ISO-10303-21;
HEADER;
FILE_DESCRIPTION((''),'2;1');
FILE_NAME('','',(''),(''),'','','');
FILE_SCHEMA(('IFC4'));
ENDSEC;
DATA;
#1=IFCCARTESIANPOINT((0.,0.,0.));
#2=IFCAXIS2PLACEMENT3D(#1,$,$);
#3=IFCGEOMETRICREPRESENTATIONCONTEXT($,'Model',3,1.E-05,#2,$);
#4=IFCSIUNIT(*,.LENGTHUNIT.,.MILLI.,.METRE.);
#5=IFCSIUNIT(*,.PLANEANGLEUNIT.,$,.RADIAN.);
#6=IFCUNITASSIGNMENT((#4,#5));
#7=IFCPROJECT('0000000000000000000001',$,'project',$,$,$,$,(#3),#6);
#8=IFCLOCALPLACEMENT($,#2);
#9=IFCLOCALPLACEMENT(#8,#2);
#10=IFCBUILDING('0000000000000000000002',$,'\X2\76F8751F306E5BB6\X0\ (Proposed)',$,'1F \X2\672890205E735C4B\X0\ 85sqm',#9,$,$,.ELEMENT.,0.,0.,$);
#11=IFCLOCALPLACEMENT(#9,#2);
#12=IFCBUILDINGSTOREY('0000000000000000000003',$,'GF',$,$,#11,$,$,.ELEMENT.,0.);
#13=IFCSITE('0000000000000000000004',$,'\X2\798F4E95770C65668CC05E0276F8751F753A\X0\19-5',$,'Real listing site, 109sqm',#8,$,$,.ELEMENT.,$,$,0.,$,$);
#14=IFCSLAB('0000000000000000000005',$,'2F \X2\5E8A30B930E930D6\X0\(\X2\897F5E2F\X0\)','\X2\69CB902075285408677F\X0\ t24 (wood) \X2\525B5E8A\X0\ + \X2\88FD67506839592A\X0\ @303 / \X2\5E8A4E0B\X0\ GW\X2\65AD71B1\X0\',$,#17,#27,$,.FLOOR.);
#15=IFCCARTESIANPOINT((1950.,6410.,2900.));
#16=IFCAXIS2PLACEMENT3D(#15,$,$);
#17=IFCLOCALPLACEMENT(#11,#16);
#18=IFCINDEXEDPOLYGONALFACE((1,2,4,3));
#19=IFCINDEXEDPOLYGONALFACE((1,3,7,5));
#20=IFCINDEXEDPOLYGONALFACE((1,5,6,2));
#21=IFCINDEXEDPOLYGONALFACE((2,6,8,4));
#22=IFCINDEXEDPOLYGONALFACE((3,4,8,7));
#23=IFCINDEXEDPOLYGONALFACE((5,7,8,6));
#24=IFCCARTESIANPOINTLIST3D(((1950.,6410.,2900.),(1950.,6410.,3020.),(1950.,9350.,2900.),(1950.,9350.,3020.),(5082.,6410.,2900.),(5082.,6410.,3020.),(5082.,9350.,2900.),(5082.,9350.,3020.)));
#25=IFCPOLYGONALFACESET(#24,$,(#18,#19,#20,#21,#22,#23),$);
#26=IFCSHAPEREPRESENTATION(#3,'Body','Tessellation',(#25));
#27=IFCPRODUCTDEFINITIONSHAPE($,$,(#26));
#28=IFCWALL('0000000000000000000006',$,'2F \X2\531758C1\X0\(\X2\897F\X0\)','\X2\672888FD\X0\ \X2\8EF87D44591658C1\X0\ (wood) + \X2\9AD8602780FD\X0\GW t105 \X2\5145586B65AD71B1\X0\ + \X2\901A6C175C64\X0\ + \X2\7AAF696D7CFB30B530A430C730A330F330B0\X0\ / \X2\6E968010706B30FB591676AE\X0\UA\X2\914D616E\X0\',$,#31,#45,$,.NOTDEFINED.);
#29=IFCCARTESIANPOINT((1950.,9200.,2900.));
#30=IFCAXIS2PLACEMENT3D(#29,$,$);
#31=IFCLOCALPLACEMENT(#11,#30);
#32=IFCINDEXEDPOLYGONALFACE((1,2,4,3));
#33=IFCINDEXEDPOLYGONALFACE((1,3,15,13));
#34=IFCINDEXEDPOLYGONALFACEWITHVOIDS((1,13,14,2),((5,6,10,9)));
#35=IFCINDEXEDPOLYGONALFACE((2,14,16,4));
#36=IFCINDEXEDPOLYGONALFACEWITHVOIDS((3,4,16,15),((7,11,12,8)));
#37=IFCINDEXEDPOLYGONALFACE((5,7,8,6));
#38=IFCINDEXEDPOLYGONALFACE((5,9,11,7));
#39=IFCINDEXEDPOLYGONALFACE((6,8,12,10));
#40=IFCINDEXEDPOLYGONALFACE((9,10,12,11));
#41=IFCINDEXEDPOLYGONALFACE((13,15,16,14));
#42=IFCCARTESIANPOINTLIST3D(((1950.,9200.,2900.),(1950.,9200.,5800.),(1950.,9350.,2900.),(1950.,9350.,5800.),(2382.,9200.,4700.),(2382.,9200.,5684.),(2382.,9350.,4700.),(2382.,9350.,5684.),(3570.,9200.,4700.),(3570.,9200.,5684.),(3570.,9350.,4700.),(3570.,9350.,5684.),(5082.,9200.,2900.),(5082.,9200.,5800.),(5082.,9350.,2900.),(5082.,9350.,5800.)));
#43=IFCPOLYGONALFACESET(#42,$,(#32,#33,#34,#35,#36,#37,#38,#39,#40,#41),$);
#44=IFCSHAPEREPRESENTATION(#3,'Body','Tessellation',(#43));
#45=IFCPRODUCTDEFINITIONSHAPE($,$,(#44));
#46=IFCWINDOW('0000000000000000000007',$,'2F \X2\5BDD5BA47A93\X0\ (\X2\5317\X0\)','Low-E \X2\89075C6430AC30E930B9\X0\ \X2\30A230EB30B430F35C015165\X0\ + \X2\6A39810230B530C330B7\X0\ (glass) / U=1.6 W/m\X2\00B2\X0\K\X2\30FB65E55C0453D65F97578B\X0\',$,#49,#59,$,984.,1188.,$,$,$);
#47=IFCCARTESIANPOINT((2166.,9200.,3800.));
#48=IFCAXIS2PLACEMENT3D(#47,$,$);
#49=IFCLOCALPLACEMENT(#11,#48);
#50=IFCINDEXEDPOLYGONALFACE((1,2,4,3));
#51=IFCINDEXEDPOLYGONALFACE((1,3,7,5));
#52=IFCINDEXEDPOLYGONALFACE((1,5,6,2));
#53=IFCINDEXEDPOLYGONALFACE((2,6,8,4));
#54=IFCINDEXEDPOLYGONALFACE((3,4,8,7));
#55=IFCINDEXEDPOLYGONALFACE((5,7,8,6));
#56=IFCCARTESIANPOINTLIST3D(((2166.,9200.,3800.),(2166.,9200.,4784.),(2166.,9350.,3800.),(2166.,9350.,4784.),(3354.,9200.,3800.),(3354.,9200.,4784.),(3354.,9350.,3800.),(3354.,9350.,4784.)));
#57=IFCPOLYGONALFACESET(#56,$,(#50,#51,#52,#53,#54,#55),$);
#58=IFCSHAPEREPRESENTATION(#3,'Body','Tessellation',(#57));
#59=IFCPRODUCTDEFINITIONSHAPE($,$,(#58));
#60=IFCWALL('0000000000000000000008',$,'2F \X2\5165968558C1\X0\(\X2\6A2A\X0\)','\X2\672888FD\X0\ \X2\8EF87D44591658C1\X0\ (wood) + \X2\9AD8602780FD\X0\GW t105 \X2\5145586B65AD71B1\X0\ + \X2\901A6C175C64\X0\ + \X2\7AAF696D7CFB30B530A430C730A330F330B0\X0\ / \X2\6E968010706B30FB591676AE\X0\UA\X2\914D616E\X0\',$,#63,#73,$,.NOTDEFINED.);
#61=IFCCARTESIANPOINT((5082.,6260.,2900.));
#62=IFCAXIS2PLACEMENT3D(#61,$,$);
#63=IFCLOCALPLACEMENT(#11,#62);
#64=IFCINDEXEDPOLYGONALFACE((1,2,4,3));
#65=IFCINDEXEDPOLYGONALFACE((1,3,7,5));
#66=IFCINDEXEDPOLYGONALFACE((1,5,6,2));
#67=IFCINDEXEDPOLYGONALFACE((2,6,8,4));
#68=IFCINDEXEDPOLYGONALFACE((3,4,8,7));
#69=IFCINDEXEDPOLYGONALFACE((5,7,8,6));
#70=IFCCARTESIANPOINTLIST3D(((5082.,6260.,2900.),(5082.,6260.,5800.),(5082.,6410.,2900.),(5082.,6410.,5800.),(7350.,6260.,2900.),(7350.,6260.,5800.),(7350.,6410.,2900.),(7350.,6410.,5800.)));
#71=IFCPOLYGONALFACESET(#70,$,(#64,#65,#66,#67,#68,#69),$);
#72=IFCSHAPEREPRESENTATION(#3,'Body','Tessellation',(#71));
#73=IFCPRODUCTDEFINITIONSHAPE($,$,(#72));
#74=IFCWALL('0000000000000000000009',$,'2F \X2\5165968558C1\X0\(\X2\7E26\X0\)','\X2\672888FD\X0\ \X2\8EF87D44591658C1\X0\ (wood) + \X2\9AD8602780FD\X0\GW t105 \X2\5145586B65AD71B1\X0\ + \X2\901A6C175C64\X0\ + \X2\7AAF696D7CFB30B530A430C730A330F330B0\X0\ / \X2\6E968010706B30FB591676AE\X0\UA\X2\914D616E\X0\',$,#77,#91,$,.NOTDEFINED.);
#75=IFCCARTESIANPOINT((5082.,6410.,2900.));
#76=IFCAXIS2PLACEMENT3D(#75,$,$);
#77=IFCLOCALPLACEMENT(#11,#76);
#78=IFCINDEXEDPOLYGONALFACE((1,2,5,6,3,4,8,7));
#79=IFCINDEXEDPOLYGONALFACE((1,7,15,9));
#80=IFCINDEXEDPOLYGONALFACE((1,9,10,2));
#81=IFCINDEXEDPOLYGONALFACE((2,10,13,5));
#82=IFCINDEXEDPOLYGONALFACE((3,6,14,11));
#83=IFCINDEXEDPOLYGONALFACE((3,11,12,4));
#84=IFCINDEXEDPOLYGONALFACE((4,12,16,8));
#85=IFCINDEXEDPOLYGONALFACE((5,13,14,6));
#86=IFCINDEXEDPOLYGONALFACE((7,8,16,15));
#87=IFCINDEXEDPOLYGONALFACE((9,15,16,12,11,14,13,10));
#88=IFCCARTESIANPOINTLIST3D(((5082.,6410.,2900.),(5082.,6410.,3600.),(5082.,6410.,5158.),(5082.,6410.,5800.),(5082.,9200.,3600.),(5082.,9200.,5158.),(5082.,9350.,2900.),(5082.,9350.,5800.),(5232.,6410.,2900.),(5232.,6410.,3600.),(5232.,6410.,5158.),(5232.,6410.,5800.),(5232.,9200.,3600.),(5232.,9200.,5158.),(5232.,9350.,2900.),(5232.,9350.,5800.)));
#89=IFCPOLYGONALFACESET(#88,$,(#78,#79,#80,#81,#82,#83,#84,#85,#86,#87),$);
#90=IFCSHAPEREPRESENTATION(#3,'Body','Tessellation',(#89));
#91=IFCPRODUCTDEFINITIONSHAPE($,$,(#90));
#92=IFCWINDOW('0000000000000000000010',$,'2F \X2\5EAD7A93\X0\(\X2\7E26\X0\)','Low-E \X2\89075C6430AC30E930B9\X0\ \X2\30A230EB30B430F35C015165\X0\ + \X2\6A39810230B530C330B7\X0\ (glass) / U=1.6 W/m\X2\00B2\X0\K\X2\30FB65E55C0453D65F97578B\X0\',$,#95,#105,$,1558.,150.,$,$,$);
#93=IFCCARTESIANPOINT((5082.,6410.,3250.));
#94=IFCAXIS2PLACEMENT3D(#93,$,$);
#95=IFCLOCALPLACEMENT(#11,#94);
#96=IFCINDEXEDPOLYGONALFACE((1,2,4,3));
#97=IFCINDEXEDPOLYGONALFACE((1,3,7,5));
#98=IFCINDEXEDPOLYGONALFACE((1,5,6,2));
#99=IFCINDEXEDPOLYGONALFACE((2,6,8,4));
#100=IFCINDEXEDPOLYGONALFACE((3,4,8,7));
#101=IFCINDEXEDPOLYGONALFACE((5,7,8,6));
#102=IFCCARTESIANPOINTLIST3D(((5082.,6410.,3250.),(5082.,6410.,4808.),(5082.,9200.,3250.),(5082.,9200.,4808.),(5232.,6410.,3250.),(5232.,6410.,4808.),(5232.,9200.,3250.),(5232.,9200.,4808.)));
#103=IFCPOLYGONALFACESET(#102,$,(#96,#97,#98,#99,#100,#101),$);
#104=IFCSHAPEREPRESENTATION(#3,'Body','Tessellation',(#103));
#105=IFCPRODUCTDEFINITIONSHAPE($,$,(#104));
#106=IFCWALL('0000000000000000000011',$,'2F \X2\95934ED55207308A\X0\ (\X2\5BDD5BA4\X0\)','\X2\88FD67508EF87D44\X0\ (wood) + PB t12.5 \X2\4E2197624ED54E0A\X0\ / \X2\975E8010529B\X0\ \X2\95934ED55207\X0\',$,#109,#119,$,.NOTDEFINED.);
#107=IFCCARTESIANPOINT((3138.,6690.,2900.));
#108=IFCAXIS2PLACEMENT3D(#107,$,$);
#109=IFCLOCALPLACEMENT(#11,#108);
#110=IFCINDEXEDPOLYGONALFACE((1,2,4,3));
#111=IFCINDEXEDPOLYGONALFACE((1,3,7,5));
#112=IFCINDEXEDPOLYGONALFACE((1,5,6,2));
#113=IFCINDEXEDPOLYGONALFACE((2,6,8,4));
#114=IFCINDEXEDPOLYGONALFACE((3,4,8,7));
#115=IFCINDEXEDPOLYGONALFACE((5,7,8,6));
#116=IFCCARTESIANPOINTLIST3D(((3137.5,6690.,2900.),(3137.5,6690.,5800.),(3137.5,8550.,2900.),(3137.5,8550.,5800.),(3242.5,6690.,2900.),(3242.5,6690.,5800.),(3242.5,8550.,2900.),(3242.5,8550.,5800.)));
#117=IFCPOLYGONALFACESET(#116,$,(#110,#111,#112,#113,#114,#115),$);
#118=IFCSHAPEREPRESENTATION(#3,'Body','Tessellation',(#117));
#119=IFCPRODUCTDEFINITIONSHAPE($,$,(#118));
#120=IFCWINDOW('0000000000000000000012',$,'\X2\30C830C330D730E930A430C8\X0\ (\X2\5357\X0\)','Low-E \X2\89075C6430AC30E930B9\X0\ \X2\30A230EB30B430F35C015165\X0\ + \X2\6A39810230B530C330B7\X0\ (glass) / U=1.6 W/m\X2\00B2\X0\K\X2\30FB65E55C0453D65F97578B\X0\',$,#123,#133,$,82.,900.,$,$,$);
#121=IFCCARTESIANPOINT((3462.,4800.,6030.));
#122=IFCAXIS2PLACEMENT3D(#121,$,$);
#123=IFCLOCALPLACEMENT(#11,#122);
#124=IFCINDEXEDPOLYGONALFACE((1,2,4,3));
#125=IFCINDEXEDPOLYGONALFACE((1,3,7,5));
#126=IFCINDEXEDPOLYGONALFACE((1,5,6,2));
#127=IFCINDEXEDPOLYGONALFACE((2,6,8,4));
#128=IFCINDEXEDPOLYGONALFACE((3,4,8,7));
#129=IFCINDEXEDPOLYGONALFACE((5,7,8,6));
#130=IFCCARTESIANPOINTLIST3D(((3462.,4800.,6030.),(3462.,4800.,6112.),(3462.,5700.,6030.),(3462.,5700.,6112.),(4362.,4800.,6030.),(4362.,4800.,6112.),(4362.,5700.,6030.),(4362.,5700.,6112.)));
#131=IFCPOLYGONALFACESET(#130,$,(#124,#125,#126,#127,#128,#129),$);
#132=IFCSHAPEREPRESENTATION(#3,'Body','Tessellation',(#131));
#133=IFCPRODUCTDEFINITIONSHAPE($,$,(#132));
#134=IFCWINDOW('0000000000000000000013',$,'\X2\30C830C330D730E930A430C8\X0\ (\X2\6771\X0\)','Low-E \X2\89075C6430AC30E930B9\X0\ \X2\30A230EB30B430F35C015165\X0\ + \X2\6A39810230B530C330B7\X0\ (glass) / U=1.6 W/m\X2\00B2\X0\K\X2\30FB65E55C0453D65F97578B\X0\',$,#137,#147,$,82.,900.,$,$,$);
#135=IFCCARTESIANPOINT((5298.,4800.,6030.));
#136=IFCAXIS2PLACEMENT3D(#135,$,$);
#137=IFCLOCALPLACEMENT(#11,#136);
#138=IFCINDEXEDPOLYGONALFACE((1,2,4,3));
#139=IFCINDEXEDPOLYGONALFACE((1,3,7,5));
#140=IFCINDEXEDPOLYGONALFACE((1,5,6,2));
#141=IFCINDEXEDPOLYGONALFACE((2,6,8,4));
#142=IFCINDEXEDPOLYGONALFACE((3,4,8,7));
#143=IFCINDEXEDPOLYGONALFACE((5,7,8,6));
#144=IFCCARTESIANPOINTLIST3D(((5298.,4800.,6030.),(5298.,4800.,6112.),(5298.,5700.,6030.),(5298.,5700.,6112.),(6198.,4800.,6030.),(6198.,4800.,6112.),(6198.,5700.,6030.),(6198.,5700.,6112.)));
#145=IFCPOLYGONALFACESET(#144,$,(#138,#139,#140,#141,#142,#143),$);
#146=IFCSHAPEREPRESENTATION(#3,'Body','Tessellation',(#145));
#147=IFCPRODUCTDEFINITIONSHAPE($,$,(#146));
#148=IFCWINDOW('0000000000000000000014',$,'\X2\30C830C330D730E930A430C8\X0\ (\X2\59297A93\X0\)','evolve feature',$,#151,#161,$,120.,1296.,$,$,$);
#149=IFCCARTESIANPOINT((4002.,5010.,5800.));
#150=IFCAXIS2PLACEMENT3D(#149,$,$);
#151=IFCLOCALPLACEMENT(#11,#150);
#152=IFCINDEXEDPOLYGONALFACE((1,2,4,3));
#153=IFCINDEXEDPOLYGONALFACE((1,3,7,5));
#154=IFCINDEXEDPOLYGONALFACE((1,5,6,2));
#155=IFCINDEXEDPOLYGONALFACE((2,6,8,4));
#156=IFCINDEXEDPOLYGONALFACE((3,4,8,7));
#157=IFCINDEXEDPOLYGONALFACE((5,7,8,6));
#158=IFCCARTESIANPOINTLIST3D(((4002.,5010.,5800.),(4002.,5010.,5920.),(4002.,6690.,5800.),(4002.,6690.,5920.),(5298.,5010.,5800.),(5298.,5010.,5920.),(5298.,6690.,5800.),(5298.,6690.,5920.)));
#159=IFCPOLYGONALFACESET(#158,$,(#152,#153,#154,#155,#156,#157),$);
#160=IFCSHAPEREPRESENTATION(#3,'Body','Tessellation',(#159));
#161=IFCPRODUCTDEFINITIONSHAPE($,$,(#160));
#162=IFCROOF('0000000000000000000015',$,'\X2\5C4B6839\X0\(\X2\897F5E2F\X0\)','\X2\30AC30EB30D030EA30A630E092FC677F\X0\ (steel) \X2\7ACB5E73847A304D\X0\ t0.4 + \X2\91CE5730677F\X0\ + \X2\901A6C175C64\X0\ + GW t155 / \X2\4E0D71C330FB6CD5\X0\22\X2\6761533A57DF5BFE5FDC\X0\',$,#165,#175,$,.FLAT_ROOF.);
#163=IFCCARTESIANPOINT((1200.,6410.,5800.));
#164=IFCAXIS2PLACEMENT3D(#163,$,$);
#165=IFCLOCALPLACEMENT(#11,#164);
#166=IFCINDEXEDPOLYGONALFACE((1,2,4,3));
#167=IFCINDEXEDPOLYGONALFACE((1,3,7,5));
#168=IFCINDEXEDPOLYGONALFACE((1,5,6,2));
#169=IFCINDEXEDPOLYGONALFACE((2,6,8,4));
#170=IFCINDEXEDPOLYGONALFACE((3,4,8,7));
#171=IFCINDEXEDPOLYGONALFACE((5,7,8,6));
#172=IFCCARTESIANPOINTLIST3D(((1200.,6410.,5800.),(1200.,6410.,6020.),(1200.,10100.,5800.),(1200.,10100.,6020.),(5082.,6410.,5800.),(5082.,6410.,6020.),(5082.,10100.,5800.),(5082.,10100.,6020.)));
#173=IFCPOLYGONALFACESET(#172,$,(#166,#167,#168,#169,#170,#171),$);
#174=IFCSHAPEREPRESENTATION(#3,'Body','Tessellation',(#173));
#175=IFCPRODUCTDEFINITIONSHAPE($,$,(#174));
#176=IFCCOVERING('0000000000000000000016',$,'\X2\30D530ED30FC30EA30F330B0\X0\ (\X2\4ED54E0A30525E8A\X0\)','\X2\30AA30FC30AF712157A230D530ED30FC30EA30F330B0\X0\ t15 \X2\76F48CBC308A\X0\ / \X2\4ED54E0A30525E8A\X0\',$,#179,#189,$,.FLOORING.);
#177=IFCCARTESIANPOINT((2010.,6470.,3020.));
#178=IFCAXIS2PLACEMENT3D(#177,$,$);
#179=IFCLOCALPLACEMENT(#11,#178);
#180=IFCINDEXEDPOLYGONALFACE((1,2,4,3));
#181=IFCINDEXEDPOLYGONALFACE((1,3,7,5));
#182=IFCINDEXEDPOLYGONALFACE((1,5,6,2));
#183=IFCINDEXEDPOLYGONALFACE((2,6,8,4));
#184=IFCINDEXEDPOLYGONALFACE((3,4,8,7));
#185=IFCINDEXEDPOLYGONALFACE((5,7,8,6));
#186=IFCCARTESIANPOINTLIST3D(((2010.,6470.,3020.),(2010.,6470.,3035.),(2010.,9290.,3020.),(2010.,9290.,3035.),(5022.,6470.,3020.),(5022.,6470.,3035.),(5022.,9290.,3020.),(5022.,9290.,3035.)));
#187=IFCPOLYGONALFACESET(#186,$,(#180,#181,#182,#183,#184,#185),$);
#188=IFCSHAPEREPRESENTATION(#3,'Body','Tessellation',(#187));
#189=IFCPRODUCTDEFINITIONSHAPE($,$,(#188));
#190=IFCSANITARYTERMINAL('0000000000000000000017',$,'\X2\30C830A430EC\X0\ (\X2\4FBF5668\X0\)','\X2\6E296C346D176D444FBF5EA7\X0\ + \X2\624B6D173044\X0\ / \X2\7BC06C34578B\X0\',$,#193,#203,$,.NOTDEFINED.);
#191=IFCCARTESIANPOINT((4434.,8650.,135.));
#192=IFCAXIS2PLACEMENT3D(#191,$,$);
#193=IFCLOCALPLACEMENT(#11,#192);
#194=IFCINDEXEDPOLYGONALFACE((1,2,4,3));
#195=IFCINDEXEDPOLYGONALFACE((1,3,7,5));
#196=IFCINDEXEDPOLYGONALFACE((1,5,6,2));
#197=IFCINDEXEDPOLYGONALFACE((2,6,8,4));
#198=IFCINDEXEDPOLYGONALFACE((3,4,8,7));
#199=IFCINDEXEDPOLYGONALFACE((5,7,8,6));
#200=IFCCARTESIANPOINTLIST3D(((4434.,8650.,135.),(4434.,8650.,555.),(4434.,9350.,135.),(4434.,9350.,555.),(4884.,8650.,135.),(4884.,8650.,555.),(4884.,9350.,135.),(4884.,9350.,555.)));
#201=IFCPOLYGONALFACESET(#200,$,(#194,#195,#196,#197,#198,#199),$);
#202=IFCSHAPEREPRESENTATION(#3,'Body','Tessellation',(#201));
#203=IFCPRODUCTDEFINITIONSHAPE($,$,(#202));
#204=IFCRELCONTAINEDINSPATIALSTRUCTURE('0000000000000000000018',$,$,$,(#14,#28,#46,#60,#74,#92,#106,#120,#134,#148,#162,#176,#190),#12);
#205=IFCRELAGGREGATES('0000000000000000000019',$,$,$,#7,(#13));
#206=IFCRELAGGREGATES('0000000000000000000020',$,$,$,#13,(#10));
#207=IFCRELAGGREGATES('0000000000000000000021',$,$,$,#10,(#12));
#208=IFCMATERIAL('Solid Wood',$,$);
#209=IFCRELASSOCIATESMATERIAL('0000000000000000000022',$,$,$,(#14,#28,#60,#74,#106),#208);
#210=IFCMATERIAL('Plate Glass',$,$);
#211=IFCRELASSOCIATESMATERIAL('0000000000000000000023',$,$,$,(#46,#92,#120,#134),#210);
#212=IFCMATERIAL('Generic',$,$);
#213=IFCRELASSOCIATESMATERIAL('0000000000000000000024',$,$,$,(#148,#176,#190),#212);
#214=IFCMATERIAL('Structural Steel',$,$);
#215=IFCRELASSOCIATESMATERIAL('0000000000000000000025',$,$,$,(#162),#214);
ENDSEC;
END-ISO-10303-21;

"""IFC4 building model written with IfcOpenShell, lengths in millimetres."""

from ifc_helpers import new_model, si_unit, frame, frame_2d, origin, place, context, project, spatial, rectangle, extrude, material, element, fill, save


model = new_model("IFC4")

# Units and contexts
model_context = context("Model", 3, precision=1e-05, world=origin())
ifc_project = project(units=[si_unit("LENGTHUNIT", "METRE", prefix="MILLI"), si_unit("PLANEANGLEUNIT", "RADIAN")], contexts=[model_context])

# Site, building, storey
site_placement = place(None, origin())
site = spatial("IfcSite", under=ifc_project, at=site_placement, Name="福井県敦賀市相生町19-5", ObjectType="Real listing site, 109sqm", CompositionType="ELEMENT", RefElevation=0.0)
building_placement = place(site_placement, origin())
building = spatial("IfcBuilding", under=site, at=building_placement, Name="相生の家 (Proposed)", ObjectType="1F 木造平屋 85sqm", CompositionType="ELEMENT", ElevationOfRefHeight=0.0, ElevationOfTerrain=0.0)
storey_placement = place(building_placement, origin())
storey = spatial("IfcBuildingStorey", under=building, at=storey_placement, Name="GF", CompositionType="ELEMENT", Elevation=0.0)

# Slab
ifc_material_1 = material(Name="Solid Wood")
slab_placement = place(storey_placement, frame((1950.0, 6410.0, 2900.0)))
element("IfcSlab", 1, at=slab_placement, inside=storey, material=ifc_material_1, Name="2F 床スラブ(西帯)", Description="構造用合板 t24 (wood) 剛床 + 製材根太 @303 / 床下 GW断熱", PredefinedType="FLOOR", context=model_context, shape_type="SweptSolid", body=[
    extrude(rectangle(XDim=3132.0, YDim=2940.0, at=frame_2d((1566.0, 1470.0))), frame((1950.0, 6410.0, 2900.0)), (0.0, 0.0, 1.0), 120.0),
])

# Wall, opening, window
wall_1_placement = place(storey_placement, frame((1950.0, 9200.0, 2900.0)))
wall_1 = element("IfcWall", 2, at=wall_1_placement, inside=storey, material=ifc_material_1, Name="2F 北壁(西)", Description="木製 軸組外壁 (wood) + 高性能GW t105 充填断熱 + 通気層 + 窯業系サイディング / 準耐火・外皮UA配慮", PredefinedType="NOTDEFINED", context=model_context, shape_type="SweptSolid", body=[
    extrude(rectangle(XDim=3132.0, YDim=150.0, at=frame_2d((1566.0, 75.0))), frame((1950.0, 9200.0, 2900.0)), (0.0, 0.0, 1.0), 2900.0),
])
opening_1_placement = place(storey_placement, frame((2166.0, 9200.0, 3800.0)))
opening_1 = element("IfcOpeningElement", 3, at=opening_1_placement, cuts=wall_1, PredefinedType="NOTDEFINED", context=model_context, shape_type="SweptSolid", body=[
    extrude(rectangle(XDim=1188.0, YDim=150.0, at=frame_2d((594.0, 75.0))), frame((2166.0, 9200.0, 3800.0)), (0.0, 0.0, 1.0), 984.0),
])
ifc_material_2 = material(Name="Plate Glass")
window_1_placement = place(storey_placement, frame((2166.0, 9200.0, 3800.0)))
window_1 = element("IfcWindow", 4, at=window_1_placement, inside=storey, material=ifc_material_2, Name="2F 寝室窓 (北)", Description="Low-E 複層ガラス アルゴン封入 + 樹脂サッシ (glass) / U=1.6 W/m²K・日射取得型", OverallHeight=984.0, OverallWidth=1188.0, context=model_context, shape_type="SweptSolid", body=[
    extrude(rectangle(XDim=1188.0, YDim=150.0, at=frame_2d((594.0, 75.0))), frame((2166.0, 9200.0, 3800.0)), (0.0, 0.0, 1.0), 984.0),
])
fill(opening_1, window_1)

# Wall
wall_2_placement = place(storey_placement, frame((5082.0, 6260.0, 2900.0)))
element("IfcWall", 5, at=wall_2_placement, inside=storey, material=ifc_material_1, Name="2F 入隅壁(横)", Description="木製 軸組外壁 (wood) + 高性能GW t105 充填断熱 + 通気層 + 窯業系サイディング / 準耐火・外皮UA配慮", PredefinedType="NOTDEFINED", context=model_context, shape_type="SweptSolid", body=[
    extrude(rectangle(XDim=2268.0, YDim=150.0, at=frame_2d((1134.0, 75.0))), frame((5082.0, 6260.0, 2900.0)), (0.0, 0.0, 1.0), 2900.0),
])

# Wall, opening, window
wall_3_placement = place(storey_placement, frame((5082.0, 6410.0, 2900.0)))
wall_3 = element("IfcWall", 6, at=wall_3_placement, inside=storey, material=ifc_material_1, Name="2F 入隅壁(縦)", Description="木製 軸組外壁 (wood) + 高性能GW t105 充填断熱 + 通気層 + 窯業系サイディング / 準耐火・外皮UA配慮", PredefinedType="NOTDEFINED", context=model_context, shape_type="SweptSolid", body=[
    extrude(rectangle(XDim=150.0, YDim=2940.0, at=frame_2d((75.0, 1470.0))), frame((5082.0, 6410.0, 2900.0)), (0.0, 0.0, 1.0), 2900.0),
])
opening_2_placement = place(storey_placement, frame((5082.0, 6410.0, 3250.0)))
opening_2 = element("IfcOpeningElement", 7, at=opening_2_placement, cuts=wall_3, PredefinedType="NOTDEFINED", context=model_context, shape_type="SweptSolid", body=[
    extrude(rectangle(XDim=150.0, YDim=2790.0, at=frame_2d((75.0, 1395.0))), frame((5082.0, 6410.0, 3250.0)), (0.0, 0.0, 1.0), 1558.0),
])
window_2_placement = place(storey_placement, frame((5082.0, 6410.0, 3250.0)))
window_2 = element("IfcWindow", 8, at=window_2_placement, inside=storey, material=ifc_material_2, Name="2F 庭窓(縦)", Description="Low-E 複層ガラス アルゴン封入 + 樹脂サッシ (glass) / U=1.6 W/m²K・日射取得型", OverallHeight=1558.0, OverallWidth=150.0, context=model_context, shape_type="SweptSolid", body=[
    extrude(rectangle(XDim=150.0, YDim=2790.0, at=frame_2d((75.0, 1395.0))), frame((5082.0, 6410.0, 3250.0)), (0.0, 0.0, 1.0), 1558.0),
])
fill(opening_2, window_2)

# Wall
wall_4_placement = place(storey_placement, frame((3138.0, 6690.0, 2900.0)))
element("IfcWall", 9, at=wall_4_placement, inside=storey, material=ifc_material_1, Name="2F 間仕切り (寝室)", Description="製材軸組 (wood) + PB t12.5 両面仕上 / 非耐力 間仕切", PredefinedType="NOTDEFINED", context=model_context, shape_type="SweptSolid", body=[
    extrude(rectangle(XDim=105.0, YDim=1860.0, at=frame_2d((52.0, 930.0))), frame((3138.0, 6690.0, 2900.0)), (0.0, 0.0, 1.0), 2900.0),
])

# Windows
window_3_placement = place(storey_placement, frame((3462.0, 4800.0, 6030.0)))
element("IfcWindow", 10, at=window_3_placement, inside=storey, material=ifc_material_2, Name="トップライト (南)", Description="Low-E 複層ガラス アルゴン封入 + 樹脂サッシ (glass) / U=1.6 W/m²K・日射取得型", OverallHeight=82.0, OverallWidth=900.0, context=model_context, shape_type="SweptSolid", body=[
    extrude(rectangle(XDim=900.0, YDim=900.0, at=frame_2d((450.0, 450.0))), frame((3462.0, 4800.0, 6030.0)), (0.0, 0.0, 1.0), 82.0),
])
window_4_placement = place(storey_placement, frame((5298.0, 4800.0, 6030.0)))
element("IfcWindow", 11, at=window_4_placement, inside=storey, material=ifc_material_2, Name="トップライト (東)", Description="Low-E 複層ガラス アルゴン封入 + 樹脂サッシ (glass) / U=1.6 W/m²K・日射取得型", OverallHeight=82.0, OverallWidth=900.0, context=model_context, shape_type="SweptSolid", body=[
    extrude(rectangle(XDim=900.0, YDim=900.0, at=frame_2d((450.0, 450.0))), frame((5298.0, 4800.0, 6030.0)), (0.0, 0.0, 1.0), 82.0),
])
ifc_material_3 = material(Name="Generic")
window_5_placement = place(storey_placement, frame((4002.0, 5010.0, 5800.0)))
element("IfcWindow", 12, at=window_5_placement, inside=storey, material=ifc_material_3, Name="トップライト (天窓)", Description="evolve feature", OverallHeight=120.0, OverallWidth=1296.0, context=model_context, shape_type="SweptSolid", body=[
    extrude(rectangle(XDim=1296.0, YDim=1680.0, at=frame_2d((648.0, 840.0))), frame((4002.0, 5010.0, 5800.0)), (0.0, 0.0, 1.0), 120.0),
])

# Roof
ifc_material_4 = material(Name="Structural Steel")
for number, where, name in (
    (13, (1200.0, 6410.0, 5800.0), "屋根(西帯)"),
):
    element("IfcRoof", number, at=place(storey_placement, frame(where)), inside=storey, material=ifc_material_4, Name=name, Description="ガルバリウム鋼板 (steel) 立平葺き t0.4 + 野地板 + 通気層 + GW t155 / 不燃・法22条区域対応", PredefinedType="FLAT_ROOF", context=model_context, shape_type="SweptSolid", body=[
        extrude(rectangle(XDim=3882.0, YDim=3690.0, at=frame_2d((1941.0, 1845.0))), frame((1200.0, 6410.0, 5800.0)), (0.0, 0.0, 1.0), 220.0),
    ])

# Covering
covering_placement = place(storey_placement, frame((2010.0, 6470.0, 3020.0)))
element("IfcCovering", 14, at=covering_placement, inside=storey, material=ifc_material_3, Name="フローリング (仕上げ床)", Description="オーク無垢フローリング t15 直貼り / 仕上げ床", PredefinedType="FLOORING", context=model_context, shape_type="SweptSolid", body=[
    extrude(rectangle(XDim=3012.0, YDim=2820.0, at=frame_2d((1506.0, 1410.0))), frame((2010.0, 6470.0, 3020.0)), (0.0, 0.0, 1.0), 15.0),
])

# Sanitary terminal
sanitary_terminal_placement = place(storey_placement, frame((4434.0, 8650.0, 135.0)))
element("IfcSanitaryTerminal", 15, at=sanitary_terminal_placement, inside=storey, material=ifc_material_3, Name="トイレ (便器)", Description="温水洗浄便座 + 手洗い / 節水型", PredefinedType="NOTDEFINED", context=model_context, shape_type="SweptSolid", body=[
    extrude(rectangle(XDim=450.0, YDim=700.0, at=frame_2d((225.0, 350.0))), frame((4434.0, 8650.0, 135.0)), (0.0, 0.0, 1.0), 420.0),
])

save(model, "model.ifc")
